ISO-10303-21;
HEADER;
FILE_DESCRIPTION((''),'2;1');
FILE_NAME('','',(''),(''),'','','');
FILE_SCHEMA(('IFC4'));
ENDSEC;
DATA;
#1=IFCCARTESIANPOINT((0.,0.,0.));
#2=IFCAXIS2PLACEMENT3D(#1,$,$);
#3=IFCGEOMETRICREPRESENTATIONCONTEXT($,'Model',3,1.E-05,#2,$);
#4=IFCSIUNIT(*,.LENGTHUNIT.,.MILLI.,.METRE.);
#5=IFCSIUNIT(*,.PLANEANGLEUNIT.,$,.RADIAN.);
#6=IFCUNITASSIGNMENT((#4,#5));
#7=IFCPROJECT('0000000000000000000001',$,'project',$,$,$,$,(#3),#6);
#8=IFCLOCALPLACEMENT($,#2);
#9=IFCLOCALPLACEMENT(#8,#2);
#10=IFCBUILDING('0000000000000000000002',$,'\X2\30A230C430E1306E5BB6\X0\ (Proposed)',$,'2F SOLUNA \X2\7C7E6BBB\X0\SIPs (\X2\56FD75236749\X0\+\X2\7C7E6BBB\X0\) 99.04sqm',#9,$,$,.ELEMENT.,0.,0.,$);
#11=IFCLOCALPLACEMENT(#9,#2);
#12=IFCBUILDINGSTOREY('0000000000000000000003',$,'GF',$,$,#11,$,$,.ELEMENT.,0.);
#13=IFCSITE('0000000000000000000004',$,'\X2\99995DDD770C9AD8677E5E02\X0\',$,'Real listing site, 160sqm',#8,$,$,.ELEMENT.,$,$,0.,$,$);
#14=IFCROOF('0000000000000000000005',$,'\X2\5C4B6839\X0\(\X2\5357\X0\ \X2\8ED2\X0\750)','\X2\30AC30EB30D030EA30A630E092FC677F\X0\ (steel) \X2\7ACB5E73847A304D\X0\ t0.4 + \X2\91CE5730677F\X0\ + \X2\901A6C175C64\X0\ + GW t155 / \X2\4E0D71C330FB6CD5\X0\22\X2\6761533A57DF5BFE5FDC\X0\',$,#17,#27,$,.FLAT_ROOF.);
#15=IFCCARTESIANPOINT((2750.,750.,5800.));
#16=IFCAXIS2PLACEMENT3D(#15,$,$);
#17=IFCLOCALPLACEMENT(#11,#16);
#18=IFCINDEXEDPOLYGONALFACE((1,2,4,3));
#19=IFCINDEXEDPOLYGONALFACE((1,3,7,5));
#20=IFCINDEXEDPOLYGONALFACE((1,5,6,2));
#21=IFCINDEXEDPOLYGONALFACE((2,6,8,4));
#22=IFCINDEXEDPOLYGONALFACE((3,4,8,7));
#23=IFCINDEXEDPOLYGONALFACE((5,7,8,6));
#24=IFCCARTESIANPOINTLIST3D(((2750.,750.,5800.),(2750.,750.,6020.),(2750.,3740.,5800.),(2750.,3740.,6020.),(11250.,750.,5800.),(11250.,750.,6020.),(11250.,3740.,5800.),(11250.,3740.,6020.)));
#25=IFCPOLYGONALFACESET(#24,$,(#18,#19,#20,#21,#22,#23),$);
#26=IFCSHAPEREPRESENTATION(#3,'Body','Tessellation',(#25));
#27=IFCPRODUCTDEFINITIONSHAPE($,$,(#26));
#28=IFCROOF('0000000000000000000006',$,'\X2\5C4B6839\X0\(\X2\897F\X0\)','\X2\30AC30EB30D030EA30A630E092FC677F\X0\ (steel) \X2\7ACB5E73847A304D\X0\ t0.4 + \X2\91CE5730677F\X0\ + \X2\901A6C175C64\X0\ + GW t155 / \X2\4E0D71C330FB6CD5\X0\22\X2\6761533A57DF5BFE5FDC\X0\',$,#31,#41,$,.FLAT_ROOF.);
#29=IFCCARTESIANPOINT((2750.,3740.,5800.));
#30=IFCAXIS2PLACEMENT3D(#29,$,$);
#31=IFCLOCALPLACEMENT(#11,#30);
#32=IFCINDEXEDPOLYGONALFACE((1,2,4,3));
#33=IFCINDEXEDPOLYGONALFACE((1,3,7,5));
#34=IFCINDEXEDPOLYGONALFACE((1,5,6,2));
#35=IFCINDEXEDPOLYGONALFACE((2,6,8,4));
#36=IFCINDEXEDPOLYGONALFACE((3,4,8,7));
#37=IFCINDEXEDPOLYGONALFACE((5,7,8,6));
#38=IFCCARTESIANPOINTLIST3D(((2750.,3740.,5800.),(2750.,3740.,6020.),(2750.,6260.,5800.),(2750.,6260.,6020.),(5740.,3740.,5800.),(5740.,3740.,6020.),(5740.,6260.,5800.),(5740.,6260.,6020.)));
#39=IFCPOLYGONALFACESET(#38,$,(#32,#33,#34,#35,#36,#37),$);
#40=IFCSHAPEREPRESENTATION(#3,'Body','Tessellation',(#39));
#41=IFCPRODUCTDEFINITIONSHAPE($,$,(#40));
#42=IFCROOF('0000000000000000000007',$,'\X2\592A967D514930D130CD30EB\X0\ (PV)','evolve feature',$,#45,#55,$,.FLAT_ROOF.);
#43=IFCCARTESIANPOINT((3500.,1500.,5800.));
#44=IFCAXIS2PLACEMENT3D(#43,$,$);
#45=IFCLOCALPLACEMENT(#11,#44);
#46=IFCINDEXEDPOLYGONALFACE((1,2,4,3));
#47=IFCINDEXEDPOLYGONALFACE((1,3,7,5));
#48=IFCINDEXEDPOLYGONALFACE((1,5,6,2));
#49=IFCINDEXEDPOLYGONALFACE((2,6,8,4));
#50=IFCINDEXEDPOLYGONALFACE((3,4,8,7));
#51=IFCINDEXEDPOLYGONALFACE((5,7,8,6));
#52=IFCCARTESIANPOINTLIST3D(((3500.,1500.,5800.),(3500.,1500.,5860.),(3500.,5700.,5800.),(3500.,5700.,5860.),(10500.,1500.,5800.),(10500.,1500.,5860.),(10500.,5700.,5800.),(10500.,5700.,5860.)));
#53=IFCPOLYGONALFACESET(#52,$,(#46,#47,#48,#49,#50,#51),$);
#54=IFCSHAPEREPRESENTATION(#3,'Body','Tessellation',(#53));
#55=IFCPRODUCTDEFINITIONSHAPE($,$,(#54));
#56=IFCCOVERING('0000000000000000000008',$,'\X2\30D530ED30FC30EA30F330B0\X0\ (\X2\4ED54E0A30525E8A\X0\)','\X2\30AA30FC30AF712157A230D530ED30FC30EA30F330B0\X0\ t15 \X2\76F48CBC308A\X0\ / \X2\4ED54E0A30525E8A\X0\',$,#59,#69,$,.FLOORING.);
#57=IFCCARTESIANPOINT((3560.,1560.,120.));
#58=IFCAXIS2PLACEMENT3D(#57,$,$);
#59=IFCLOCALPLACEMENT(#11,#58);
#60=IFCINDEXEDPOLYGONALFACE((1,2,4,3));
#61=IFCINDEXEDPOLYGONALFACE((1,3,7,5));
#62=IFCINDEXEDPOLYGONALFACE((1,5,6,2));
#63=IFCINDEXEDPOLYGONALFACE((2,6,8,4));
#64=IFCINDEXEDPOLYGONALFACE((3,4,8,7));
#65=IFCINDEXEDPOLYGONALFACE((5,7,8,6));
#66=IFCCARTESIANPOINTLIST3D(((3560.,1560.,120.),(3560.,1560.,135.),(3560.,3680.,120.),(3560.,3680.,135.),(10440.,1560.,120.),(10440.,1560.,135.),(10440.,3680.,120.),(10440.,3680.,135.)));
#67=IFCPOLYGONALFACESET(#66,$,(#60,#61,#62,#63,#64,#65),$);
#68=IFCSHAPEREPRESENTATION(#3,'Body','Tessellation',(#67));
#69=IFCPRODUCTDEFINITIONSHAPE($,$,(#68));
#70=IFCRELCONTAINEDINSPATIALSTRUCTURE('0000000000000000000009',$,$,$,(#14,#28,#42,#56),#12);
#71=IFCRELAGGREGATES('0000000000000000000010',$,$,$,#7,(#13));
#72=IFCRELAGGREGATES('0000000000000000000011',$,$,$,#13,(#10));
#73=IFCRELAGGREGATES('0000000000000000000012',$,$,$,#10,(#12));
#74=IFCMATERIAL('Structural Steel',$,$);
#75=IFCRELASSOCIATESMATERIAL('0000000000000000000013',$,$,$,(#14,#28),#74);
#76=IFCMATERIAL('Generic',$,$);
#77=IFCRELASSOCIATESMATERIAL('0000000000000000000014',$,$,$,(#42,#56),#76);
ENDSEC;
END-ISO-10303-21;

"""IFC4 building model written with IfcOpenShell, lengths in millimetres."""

from ifc_helpers import new_model, si_unit, frame, frame_2d, origin, place, context, project, spatial, rectangle, extrude, material, element, save


model = new_model("IFC4")

# Units and contexts
model_context = context("Model", 3, precision=1e-05, world=origin())
ifc_project = project(units=[si_unit("LENGTHUNIT", "METRE", prefix="MILLI"), si_unit("PLANEANGLEUNIT", "RADIAN")], contexts=[model_context])

# Site, building, storey
site_placement = place(None, origin())
site = spatial("IfcSite", under=ifc_project, at=site_placement, Name="香川県高松市", ObjectType="Real listing site, 160sqm", CompositionType="ELEMENT", RefElevation=0.0)
building_placement = place(site_placement, origin())
building = spatial("IfcBuilding", under=site, at=building_placement, Name="アツメの家 (Proposed)", ObjectType="2F SOLUNA 籾殻SIPs (国産杉+籾殻) 99.04sqm", CompositionType="ELEMENT", ElevationOfRefHeight=0.0, ElevationOfTerrain=0.0)
storey_placement = place(building_placement, origin())
storey = spatial("IfcBuildingStorey", under=building, at=storey_placement, Name="GF", CompositionType="ELEMENT", Elevation=0.0)

# Shared definitions
ifc_material_1 = material(Name="Generic")

# Roofs
ifc_material_2 = material(Name="Structural Steel")
roof_1_placement = place(storey_placement, frame((2750.0, 750.0, 5800.0)))
element("IfcRoof", 1, at=roof_1_placement, inside=storey, material=ifc_material_2, Name="屋根(南 軒750)", Description="ガルバリウム鋼板 (steel) 立平葺き t0.4 + 野地板 + 通気層 + GW t155 / 不燃・法22条区域対応", PredefinedType="FLAT_ROOF", context=model_context, shape_type="SweptSolid", body=[
    extrude(rectangle(XDim=8500.0, YDim=2990.0, at=frame_2d((4250.0, 1495.0))), frame((2750.0, 750.0, 5800.0)), (0.0, 0.0, 1.0), 220.0),
])
roof_2_placement = place(storey_placement, frame((2750.0, 3740.0, 5800.0)))
element("IfcRoof", 2, at=roof_2_placement, inside=storey, material=ifc_material_2, Name="屋根(西)", Description="ガルバリウム鋼板 (steel) 立平葺き t0.4 + 野地板 + 通気層 + GW t155 / 不燃・法22条区域対応", PredefinedType="FLAT_ROOF", context=model_context, shape_type="SweptSolid", body=[
    extrude(rectangle(XDim=2990.0, YDim=2520.0, at=frame_2d((1495.0, 1260.0))), frame((2750.0, 3740.0, 5800.0)), (0.0, 0.0, 1.0), 220.0),
])
roof_3_placement = place(storey_placement, frame((3500.0, 1500.0, 5800.0)))
element("IfcRoof", 3, at=roof_3_placement, inside=storey, material=ifc_material_1, Name="太陽光パネル (PV)", Description="evolve feature", PredefinedType="FLAT_ROOF", context=model_context, shape_type="SweptSolid", body=[
    extrude(rectangle(XDim=7000.0, YDim=4200.0, at=frame_2d((3500.0, 2100.0))), frame((3500.0, 1500.0, 5800.0)), (0.0, 0.0, 1.0), 60.0),
])

# Covering
covering_placement = place(storey_placement, frame((3560.0, 1560.0, 120.0)))
element("IfcCovering", 4, at=covering_placement, inside=storey, material=ifc_material_1, Name="フローリング (仕上げ床)", Description="オーク無垢フローリング t15 直貼り / 仕上げ床", PredefinedType="FLOORING", context=model_context, shape_type="SweptSolid", body=[
    extrude(rectangle(XDim=6880.0, YDim=2120.0, at=frame_2d((3440.0, 1060.0))), frame((3560.0, 1560.0, 120.0)), (0.0, 0.0, 1.0), 15.0),
])

save(model, "model.ifc")
